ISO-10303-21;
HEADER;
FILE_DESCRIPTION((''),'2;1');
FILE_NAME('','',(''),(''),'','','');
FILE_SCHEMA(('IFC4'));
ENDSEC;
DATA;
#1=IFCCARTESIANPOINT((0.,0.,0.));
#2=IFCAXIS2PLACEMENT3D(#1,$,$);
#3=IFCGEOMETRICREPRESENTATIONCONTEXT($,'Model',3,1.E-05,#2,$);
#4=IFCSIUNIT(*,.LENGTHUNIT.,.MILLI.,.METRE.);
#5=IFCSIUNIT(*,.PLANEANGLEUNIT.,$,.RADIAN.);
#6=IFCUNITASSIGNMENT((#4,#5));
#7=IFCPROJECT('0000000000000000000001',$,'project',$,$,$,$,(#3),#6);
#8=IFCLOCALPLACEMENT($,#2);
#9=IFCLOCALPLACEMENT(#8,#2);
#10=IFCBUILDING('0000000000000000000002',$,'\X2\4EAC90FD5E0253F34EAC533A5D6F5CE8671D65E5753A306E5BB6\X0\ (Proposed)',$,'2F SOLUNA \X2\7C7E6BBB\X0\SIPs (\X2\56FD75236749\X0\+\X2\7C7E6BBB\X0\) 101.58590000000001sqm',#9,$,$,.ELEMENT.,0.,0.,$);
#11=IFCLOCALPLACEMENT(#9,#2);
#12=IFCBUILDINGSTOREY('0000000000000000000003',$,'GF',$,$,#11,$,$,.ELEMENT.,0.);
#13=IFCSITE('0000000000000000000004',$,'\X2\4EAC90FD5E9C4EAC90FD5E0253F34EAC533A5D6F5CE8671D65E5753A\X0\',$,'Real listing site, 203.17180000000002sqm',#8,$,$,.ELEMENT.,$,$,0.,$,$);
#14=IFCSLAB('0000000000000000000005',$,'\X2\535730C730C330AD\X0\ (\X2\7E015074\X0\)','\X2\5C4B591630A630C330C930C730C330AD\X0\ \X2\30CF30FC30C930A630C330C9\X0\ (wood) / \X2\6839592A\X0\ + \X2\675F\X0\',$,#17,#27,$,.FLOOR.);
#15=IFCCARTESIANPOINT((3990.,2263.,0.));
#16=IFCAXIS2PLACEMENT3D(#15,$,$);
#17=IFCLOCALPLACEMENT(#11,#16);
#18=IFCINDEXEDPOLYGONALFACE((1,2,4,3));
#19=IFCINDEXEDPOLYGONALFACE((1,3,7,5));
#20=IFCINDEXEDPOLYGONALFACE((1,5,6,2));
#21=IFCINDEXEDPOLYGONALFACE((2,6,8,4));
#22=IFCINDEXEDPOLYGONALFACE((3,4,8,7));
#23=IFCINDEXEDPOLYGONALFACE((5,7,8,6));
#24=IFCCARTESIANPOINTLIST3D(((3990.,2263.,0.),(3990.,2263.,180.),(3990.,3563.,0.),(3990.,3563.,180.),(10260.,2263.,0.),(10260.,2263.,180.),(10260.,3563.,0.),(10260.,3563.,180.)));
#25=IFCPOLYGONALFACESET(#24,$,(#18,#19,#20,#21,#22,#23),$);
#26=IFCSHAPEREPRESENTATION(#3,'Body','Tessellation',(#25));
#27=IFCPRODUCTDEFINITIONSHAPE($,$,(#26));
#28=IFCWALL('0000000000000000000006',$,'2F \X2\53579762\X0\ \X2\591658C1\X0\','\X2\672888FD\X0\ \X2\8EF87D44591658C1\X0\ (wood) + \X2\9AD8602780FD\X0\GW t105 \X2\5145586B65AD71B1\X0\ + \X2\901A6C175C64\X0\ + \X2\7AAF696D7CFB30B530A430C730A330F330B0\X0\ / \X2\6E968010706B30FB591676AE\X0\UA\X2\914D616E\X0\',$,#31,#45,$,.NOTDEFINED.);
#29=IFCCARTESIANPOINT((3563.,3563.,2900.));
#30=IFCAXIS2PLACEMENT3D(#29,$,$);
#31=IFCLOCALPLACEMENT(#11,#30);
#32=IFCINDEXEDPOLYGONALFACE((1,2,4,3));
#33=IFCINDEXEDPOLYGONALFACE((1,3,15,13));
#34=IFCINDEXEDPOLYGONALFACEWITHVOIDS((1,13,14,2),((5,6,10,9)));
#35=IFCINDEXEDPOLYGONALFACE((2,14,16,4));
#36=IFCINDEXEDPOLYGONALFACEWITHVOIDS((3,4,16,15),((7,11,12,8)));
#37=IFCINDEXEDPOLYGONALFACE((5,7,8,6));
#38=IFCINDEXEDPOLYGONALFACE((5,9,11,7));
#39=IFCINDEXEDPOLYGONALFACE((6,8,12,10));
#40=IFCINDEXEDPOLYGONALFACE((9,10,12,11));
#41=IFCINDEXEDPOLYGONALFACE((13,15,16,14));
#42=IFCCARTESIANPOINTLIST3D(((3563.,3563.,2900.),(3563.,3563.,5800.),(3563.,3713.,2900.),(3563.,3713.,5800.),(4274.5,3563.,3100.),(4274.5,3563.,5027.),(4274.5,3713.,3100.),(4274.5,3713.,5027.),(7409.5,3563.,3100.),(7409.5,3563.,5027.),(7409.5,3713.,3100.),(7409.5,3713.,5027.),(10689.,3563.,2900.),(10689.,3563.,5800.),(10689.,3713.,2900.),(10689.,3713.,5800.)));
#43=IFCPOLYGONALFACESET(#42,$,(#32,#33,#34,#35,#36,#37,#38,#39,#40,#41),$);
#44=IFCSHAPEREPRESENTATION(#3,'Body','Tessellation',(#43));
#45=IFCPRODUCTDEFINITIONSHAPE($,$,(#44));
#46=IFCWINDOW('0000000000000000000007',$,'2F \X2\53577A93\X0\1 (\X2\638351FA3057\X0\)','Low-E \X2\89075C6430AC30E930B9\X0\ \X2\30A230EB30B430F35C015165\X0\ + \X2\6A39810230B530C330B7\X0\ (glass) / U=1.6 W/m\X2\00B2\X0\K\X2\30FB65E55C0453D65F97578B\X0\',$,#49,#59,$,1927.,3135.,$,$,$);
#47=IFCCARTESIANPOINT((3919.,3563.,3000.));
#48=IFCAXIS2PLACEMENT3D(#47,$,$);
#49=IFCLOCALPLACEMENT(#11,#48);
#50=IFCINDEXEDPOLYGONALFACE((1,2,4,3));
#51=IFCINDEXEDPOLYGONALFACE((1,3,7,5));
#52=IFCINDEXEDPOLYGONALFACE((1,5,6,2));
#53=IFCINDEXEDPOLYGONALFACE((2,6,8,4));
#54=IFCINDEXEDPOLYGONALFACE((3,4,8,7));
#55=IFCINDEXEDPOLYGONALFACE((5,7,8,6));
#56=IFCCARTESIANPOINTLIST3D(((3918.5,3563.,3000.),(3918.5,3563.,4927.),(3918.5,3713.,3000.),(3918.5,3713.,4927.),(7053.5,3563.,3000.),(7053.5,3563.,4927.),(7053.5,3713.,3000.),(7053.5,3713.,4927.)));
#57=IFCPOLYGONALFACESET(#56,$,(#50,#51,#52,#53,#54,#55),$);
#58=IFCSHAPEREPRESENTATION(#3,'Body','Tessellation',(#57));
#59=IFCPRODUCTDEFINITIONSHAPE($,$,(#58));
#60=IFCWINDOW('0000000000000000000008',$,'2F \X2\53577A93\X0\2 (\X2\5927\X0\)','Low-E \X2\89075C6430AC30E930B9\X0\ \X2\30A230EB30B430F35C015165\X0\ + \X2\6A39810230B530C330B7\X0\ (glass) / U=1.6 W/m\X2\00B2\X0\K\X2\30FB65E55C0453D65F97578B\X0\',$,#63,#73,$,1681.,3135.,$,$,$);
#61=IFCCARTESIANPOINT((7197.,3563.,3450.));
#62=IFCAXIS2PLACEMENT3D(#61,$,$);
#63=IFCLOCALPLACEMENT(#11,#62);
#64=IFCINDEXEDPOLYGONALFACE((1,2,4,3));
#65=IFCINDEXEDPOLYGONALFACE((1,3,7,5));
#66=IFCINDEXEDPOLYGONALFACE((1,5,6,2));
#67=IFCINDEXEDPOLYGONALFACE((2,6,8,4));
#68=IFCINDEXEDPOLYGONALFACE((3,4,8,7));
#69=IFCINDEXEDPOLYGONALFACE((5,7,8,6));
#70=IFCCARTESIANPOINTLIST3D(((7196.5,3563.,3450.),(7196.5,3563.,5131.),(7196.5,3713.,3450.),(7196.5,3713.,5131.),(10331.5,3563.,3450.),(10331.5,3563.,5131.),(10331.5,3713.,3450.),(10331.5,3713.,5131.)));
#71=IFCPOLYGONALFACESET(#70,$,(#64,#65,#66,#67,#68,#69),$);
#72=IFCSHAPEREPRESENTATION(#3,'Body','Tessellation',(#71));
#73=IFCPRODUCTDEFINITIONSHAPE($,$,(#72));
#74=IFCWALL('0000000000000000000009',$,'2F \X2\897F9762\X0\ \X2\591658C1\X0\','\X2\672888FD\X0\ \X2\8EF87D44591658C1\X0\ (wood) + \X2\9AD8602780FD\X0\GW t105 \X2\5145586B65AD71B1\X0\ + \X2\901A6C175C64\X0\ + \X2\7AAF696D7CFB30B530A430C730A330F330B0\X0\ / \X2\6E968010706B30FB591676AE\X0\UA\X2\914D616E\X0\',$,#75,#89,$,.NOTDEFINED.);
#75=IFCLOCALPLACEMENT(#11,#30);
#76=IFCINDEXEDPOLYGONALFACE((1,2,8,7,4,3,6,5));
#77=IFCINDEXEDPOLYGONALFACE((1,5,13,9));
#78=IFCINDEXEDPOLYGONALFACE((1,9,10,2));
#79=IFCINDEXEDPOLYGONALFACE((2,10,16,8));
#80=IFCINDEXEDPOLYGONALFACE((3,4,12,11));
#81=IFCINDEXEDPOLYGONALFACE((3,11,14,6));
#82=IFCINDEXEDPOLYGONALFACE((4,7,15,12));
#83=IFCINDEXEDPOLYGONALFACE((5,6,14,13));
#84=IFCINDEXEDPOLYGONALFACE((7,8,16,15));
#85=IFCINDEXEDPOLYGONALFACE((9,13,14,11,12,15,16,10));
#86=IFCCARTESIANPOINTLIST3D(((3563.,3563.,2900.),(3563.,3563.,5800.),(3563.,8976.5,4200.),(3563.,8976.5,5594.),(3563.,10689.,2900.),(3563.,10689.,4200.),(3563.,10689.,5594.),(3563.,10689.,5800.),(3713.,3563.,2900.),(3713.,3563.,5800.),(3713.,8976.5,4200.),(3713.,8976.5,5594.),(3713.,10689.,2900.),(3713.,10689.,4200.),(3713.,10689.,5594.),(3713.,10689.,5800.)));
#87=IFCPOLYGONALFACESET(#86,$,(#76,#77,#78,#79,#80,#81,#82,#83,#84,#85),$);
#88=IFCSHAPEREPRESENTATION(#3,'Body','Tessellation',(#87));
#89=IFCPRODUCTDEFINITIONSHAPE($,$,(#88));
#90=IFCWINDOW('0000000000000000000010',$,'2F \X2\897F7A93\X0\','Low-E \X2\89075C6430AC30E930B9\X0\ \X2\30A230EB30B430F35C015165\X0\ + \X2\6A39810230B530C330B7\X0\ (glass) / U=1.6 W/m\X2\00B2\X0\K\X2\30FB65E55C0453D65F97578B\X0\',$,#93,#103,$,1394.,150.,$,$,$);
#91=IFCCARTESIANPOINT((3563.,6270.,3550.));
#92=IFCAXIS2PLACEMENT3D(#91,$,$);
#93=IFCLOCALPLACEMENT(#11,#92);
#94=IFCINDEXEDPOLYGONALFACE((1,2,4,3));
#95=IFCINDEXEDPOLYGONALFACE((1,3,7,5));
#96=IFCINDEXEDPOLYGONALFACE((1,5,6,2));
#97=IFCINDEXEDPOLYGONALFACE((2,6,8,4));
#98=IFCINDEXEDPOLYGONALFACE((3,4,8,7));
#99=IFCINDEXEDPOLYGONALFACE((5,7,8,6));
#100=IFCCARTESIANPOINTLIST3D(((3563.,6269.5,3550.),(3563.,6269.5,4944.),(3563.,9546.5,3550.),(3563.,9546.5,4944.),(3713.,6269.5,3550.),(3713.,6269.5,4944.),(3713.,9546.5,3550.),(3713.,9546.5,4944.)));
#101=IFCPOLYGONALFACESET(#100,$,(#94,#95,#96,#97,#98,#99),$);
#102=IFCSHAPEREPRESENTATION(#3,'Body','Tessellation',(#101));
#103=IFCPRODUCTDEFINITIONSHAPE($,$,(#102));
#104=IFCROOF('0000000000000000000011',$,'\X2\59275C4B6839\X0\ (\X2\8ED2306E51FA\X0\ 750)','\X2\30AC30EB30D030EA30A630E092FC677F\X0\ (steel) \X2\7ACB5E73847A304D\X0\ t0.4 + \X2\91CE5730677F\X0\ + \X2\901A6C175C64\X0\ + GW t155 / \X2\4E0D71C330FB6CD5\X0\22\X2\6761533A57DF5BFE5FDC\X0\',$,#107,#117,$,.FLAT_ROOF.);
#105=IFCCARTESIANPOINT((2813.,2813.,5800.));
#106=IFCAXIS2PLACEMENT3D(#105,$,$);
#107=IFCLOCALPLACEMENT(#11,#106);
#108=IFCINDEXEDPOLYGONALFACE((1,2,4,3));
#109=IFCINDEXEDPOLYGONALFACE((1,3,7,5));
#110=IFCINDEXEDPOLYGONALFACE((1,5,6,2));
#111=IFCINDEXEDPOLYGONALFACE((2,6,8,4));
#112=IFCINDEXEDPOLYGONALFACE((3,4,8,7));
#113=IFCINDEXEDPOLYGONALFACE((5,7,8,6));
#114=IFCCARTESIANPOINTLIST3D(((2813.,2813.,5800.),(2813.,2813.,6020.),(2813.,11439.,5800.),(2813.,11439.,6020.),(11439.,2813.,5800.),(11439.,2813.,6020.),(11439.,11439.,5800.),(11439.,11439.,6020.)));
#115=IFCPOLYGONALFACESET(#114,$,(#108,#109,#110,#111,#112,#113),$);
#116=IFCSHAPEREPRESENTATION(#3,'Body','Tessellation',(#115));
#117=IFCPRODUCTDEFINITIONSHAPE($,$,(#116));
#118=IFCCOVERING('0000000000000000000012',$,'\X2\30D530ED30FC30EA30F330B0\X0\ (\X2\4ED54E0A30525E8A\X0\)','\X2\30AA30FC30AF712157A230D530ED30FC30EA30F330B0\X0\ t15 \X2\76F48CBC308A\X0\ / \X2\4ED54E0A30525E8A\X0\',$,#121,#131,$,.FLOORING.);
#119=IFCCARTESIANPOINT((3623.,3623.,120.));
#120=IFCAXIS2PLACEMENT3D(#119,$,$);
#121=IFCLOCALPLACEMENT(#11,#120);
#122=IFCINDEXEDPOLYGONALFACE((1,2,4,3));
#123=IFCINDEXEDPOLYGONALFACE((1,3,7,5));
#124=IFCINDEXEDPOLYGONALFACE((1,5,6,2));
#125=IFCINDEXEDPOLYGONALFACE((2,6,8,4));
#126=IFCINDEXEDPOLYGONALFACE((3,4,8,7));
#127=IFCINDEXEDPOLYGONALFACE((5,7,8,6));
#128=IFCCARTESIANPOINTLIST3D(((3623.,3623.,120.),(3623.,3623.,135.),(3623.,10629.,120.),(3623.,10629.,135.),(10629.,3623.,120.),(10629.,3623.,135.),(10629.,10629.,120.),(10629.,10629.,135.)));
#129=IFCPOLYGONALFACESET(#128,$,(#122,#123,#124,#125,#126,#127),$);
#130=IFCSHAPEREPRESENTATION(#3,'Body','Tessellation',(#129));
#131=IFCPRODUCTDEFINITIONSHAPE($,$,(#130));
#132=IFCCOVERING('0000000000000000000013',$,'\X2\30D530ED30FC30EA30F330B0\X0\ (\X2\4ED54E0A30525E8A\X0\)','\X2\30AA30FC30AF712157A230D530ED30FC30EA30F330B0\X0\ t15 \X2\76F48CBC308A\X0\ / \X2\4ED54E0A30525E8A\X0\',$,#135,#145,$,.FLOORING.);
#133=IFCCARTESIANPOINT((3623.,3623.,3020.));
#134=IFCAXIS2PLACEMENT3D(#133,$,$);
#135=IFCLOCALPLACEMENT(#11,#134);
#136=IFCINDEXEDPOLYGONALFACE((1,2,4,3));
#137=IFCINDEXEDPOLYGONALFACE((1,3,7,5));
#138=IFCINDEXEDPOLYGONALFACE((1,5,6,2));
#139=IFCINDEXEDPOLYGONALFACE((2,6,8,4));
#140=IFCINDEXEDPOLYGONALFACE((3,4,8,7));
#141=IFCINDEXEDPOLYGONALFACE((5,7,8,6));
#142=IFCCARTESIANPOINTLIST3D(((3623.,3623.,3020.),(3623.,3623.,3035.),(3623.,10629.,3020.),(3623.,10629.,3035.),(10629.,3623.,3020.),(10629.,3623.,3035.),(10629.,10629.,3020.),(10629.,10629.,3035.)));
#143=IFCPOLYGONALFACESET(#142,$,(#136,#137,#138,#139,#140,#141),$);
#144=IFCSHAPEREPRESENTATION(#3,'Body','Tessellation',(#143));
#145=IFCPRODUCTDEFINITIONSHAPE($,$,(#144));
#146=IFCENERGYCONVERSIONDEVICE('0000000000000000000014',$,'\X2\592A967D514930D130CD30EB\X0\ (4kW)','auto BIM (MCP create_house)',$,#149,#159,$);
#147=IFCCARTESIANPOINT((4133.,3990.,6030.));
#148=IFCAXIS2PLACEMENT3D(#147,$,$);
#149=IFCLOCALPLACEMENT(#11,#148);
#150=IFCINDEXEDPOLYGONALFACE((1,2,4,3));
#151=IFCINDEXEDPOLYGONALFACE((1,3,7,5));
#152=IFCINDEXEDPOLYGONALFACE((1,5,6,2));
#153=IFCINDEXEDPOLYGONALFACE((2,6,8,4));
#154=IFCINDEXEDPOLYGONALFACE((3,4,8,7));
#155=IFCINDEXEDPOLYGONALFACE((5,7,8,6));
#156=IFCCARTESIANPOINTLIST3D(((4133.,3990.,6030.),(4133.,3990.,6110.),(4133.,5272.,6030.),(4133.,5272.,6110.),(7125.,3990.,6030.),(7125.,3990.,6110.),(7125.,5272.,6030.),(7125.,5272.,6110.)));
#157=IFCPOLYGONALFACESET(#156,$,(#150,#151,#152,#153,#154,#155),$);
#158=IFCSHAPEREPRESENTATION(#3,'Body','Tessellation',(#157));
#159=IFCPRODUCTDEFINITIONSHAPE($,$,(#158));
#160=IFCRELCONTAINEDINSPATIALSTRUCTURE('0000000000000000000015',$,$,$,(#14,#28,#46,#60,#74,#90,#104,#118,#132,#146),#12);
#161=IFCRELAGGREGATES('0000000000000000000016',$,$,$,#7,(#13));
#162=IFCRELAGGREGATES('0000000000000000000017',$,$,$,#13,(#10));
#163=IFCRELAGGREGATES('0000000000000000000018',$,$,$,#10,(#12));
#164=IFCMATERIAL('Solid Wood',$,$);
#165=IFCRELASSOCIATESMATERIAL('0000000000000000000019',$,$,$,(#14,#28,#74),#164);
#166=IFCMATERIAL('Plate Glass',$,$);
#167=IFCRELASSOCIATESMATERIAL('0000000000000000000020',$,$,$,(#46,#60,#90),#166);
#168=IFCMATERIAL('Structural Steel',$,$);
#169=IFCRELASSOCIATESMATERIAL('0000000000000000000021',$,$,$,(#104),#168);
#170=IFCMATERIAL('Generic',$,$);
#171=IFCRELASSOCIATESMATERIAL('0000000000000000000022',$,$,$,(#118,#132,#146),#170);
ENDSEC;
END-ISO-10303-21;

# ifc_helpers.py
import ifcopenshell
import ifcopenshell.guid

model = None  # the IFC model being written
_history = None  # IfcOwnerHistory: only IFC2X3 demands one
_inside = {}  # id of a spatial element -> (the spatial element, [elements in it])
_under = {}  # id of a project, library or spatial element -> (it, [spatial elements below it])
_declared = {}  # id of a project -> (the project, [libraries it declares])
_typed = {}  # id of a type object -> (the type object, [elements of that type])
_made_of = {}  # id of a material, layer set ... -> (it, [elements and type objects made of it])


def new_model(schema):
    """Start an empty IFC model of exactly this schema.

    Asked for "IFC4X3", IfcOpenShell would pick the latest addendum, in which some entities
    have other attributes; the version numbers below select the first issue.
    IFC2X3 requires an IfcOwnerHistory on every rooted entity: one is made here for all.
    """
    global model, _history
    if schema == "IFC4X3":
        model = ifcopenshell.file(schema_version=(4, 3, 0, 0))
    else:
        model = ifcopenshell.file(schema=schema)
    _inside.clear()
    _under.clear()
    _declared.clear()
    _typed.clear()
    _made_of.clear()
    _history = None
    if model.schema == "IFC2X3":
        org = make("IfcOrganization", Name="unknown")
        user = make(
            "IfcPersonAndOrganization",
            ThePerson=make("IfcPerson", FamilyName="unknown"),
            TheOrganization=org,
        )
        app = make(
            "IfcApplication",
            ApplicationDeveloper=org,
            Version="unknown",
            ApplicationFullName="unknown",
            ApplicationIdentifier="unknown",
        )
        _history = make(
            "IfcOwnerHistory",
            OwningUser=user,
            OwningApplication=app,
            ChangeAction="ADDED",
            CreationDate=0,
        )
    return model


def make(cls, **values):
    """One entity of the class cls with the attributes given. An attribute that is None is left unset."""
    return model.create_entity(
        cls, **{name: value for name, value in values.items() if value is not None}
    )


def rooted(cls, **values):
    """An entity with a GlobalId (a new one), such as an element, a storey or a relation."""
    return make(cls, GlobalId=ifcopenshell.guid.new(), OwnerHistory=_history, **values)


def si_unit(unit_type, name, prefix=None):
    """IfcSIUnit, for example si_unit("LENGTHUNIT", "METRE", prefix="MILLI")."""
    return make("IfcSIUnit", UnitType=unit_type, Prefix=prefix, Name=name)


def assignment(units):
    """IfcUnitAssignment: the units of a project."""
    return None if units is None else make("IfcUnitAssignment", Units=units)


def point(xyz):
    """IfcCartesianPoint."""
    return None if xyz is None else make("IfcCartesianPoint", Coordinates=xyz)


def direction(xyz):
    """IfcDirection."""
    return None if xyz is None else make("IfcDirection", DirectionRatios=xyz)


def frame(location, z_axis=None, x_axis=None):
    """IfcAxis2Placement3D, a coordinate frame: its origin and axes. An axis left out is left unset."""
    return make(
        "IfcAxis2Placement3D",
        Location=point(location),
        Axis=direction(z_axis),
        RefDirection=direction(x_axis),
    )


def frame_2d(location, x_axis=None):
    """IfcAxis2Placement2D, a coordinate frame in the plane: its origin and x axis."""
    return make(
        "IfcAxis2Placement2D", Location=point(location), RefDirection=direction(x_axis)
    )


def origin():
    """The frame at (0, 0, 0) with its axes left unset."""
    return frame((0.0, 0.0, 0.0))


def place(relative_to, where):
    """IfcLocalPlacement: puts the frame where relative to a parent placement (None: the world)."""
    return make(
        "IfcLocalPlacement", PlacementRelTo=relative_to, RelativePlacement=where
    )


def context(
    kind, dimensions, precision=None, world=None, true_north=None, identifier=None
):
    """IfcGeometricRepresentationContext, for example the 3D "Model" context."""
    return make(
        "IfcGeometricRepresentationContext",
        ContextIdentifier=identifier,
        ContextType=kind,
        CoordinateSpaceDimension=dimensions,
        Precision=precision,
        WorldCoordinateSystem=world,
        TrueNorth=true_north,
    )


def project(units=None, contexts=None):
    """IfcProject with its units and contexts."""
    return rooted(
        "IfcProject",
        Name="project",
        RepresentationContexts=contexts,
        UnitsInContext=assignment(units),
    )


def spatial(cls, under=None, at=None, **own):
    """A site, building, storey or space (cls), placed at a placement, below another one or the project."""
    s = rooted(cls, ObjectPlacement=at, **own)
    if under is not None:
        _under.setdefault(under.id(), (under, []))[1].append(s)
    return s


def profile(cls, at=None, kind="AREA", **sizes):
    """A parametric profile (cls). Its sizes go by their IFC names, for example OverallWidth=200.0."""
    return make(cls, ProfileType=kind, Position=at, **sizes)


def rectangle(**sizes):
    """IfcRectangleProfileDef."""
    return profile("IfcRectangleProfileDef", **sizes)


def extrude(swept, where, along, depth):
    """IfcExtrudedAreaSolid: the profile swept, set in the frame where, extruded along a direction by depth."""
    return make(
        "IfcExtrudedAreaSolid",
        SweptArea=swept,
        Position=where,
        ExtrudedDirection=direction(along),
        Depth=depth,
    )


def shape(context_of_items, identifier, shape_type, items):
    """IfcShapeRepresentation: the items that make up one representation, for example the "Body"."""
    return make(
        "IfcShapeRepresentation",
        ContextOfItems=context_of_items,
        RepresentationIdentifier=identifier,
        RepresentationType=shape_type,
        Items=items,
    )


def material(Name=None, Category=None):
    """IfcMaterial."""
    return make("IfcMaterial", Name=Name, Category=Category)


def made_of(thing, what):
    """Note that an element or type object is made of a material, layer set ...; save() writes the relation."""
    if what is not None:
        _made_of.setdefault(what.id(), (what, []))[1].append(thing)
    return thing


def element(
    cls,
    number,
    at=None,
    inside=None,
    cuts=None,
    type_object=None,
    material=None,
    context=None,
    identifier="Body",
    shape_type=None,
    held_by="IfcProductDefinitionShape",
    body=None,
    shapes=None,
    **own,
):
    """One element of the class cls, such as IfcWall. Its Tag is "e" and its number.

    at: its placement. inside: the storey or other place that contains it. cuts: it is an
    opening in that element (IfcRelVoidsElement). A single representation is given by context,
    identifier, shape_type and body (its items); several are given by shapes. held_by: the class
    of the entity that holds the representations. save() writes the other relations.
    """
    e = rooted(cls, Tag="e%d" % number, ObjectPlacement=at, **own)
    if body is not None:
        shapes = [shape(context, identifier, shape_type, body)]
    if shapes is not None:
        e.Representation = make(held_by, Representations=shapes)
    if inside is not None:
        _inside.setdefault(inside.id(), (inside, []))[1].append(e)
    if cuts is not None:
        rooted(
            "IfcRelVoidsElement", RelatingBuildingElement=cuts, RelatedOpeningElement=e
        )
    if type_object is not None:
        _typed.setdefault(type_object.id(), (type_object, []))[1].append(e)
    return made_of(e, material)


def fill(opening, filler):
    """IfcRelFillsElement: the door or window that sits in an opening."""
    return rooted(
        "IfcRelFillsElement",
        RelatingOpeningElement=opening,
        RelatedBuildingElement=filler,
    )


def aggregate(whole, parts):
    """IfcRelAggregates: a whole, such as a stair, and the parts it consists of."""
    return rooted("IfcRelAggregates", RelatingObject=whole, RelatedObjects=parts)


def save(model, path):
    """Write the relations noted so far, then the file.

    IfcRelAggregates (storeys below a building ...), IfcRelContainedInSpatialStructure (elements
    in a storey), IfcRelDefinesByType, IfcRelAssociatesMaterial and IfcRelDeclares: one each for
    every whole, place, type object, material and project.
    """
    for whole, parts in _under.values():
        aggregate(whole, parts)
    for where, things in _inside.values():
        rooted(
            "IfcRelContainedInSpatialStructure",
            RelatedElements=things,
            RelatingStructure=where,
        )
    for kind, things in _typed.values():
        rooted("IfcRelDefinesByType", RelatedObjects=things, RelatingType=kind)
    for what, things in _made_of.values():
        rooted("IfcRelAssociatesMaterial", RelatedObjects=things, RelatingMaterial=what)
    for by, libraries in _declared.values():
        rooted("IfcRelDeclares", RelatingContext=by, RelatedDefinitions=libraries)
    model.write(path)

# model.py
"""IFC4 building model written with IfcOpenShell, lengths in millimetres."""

from ifc_helpers import new_model, si_unit, frame, frame_2d, origin, place, context, project, spatial, rectangle, extrude, material, element, fill, save


model = new_model("IFC4")

# Units and contexts
model_context = context("Model", 3, precision=1e-05, world=origin())
ifc_project = project(units=[si_unit("LENGTHUNIT", "METRE", prefix="MILLI"), si_unit("PLANEANGLEUNIT", "RADIAN")], contexts=[model_context])

# Site, building, storey
site_placement = place(None, origin())
site = spatial("IfcSite", under=ifc_project, at=site_placement, Name="京都府京都市右京区嵯峨朝日町", ObjectType="Real listing site, 203.17180000000002sqm", CompositionType="ELEMENT", RefElevation=0.0)
building_placement = place(site_placement, origin())
building = spatial("IfcBuilding", under=site, at=building_placement, Name="京都市右京区嵯峨朝日町の家 (Proposed)", ObjectType="2F SOLUNA 籾殻SIPs (国産杉+籾殻) 101.58590000000001sqm", CompositionType="ELEMENT", ElevationOfRefHeight=0.0, ElevationOfTerrain=0.0)
storey_placement = place(building_placement, origin())
storey = spatial("IfcBuildingStorey", under=building, at=storey_placement, Name="GF", CompositionType="ELEMENT", Elevation=0.0)

# Slab
ifc_material_1 = material(Name="Solid Wood")
slab_1_placement = place(storey_placement, frame((3990.0, 2263.0, 0.0)))
element("IfcSlab", 1, at=slab_1_placement, inside=storey, material=ifc_material_1, Name="南デッキ (縁側)", Description="屋外ウッドデッキ ハードウッド (wood) / 根太 + 束", PredefinedType="FLOOR", context=model_context, shape_type="SweptSolid", body=[
    extrude(rectangle(XDim=6270.0, YDim=1300.0, at=frame_2d((3135.0, 650.0))), frame((3990.0, 2263.0, 0.0)), (0.0, 0.0, 1.0), 180.0),
])

# Shared definitions
ifc_material_2 = material(Name="Plate Glass")

# Wall, openings, windows
wall_1_placement = place(storey_placement, frame((3563.0, 3563.0, 2900.0)))
wall_1 = element("IfcWall", 2, at=wall_1_placement, inside=storey, material=ifc_material_1, Name="2F 南面 外壁", Description="木製 軸組外壁 (wood) + 高性能GW t105 充填断熱 + 通気層 + 窯業系サイディング / 準耐火・外皮UA配慮", PredefinedType="NOTDEFINED", context=model_context, shape_type="SweptSolid", body=[
    extrude(rectangle(XDim=7126.0, YDim=150.0, at=frame_2d((3563.0, 75.0))), frame((3563.0, 3563.0, 2900.0)), (0.0, 0.0, 1.0), 2900.0),
])
opening_1_placement = place(storey_placement, frame((3919.0, 3563.0, 3000.0)))
opening_1 = element("IfcOpeningElement", 3, at=opening_1_placement, cuts=wall_1, PredefinedType="NOTDEFINED", context=model_context, shape_type="SweptSolid", body=[
    extrude(rectangle(XDim=3135.0, YDim=150.0, at=frame_2d((1567.0, 75.0))), frame((3919.0, 3563.0, 3000.0)), (0.0, 0.0, 1.0), 1927.0),
])
opening_2_placement = place(storey_placement, frame((7197.0, 3563.0, 3450.0)))
opening_2 = element("IfcOpeningElement", 4, at=opening_2_placement, cuts=wall_1, PredefinedType="NOTDEFINED", context=model_context, shape_type="SweptSolid", body=[
    extrude(rectangle(XDim=3135.0, YDim=150.0, at=frame_2d((1567.0, 75.0))), frame((7197.0, 3563.0, 3450.0)), (0.0, 0.0, 1.0), 1681.0),
])
window_1_placement = place(storey_placement, frame((3919.0, 3563.0, 3000.0)))
window_1 = element("IfcWindow", 5, at=window_1_placement, inside=storey, material=ifc_material_2, Name="2F 南窓1 (掃出し)", Description="Low-E 複層ガラス アルゴン封入 + 樹脂サッシ (glass) / U=1.6 W/m²K・日射取得型", OverallHeight=1927.0, OverallWidth=3135.0, context=model_context, shape_type="SweptSolid", body=[
    extrude(rectangle(XDim=3135.0, YDim=150.0, at=frame_2d((1567.0, 75.0))), frame((3919.0, 3563.0, 3000.0)), (0.0, 0.0, 1.0), 1927.0),
])
fill(opening_1, window_1)
window_2_placement = place(storey_placement, frame((7197.0, 3563.0, 3450.0)))
window_2 = element("IfcWindow", 6, at=window_2_placement, inside=storey, material=ifc_material_2, Name="2F 南窓2 (大)", Description="Low-E 複層ガラス アルゴン封入 + 樹脂サッシ (glass) / U=1.6 W/m²K・日射取得型", OverallHeight=1681.0, OverallWidth=3135.0, context=model_context, shape_type="SweptSolid", body=[
    extrude(rectangle(XDim=3135.0, YDim=150.0, at=frame_2d((1567.0, 75.0))), frame((7197.0, 3563.0, 3450.0)), (0.0, 0.0, 1.0), 1681.0),
])
fill(opening_2, window_2)

# Wall, opening, window
wall_2_placement = place(storey_placement, frame((3563.0, 3563.0, 2900.0)))
wall_2 = element("IfcWall", 7, at=wall_2_placement, inside=storey, material=ifc_material_1, Name="2F 西面 外壁", Description="木製 軸組外壁 (wood) + 高性能GW t105 充填断熱 + 通気層 + 窯業系サイディング / 準耐火・外皮UA配慮", PredefinedType="NOTDEFINED", context=model_context, shape_type="SweptSolid", body=[
    extrude(rectangle(XDim=150.0, YDim=7126.0, at=frame_2d((75.0, 3563.0))), frame((3563.0, 3563.0, 2900.0)), (0.0, 0.0, 1.0), 2900.0),
])
opening_3_placement = place(storey_placement, frame((3563.0, 6270.0, 3550.0)))
opening_3 = element("IfcOpeningElement", 8, at=opening_3_placement, cuts=wall_2, PredefinedType="NOTDEFINED", context=model_context, shape_type="SweptSolid", body=[
    extrude(rectangle(XDim=150.0, YDim=3277.0, at=frame_2d((75.0, 1638.0))), frame((3563.0, 6270.0, 3550.0)), (0.0, 0.0, 1.0), 1394.0),
])
window_3_placement = place(storey_placement, frame((3563.0, 6270.0, 3550.0)))
window_3 = element("IfcWindow", 9, at=window_3_placement, inside=storey, material=ifc_material_2, Name="2F 西窓", Description="Low-E 複層ガラス アルゴン封入 + 樹脂サッシ (glass) / U=1.6 W/m²K・日射取得型", OverallHeight=1394.0, OverallWidth=150.0, context=model_context, shape_type="SweptSolid", body=[
    extrude(rectangle(XDim=150.0, YDim=3277.0, at=frame_2d((75.0, 1638.0))), frame((3563.0, 6270.0, 3550.0)), (0.0, 0.0, 1.0), 1394.0),
])
fill(opening_3, window_3)

# Roof
ifc_material_3 = material(Name="Structural Steel")
roof_placement = place(storey_placement, frame((2813.0, 2813.0, 5800.0)))
element("IfcRoof", 10, at=roof_placement, inside=storey, material=ifc_material_3, Name="大屋根 (軒の出 750)", Description="ガルバリウム鋼板 (steel) 立平葺き t0.4 + 野地板 + 通気層 + GW t155 / 不燃・法22条区域対応", PredefinedType="FLAT_ROOF", context=model_context, shape_type="SweptSolid", body=[
    extrude(rectangle(XDim=8626.0, YDim=8626.0, at=frame_2d((4313.0, 4313.0))), frame((2813.0, 2813.0, 5800.0)), (0.0, 0.0, 1.0), 220.0),
])

# Coverings
ifc_material_4 = material(Name="Generic")
covering_1_placement = place(storey_placement, frame((3623.0, 3623.0, 120.0)))
element("IfcCovering", 11, at=covering_1_placement, inside=storey, material=ifc_material_4, Name="フローリング (仕上げ床)", Description="オーク無垢フローリング t15 直貼り / 仕上げ床", PredefinedType="FLOORING", context=model_context, shape_type="SweptSolid", body=[
    extrude(rectangle(XDim=7006.0, YDim=7006.0, at=frame_2d((3503.0, 3503.0))), frame((3623.0, 3623.0, 120.0)), (0.0, 0.0, 1.0), 15.0),
])
covering_2_placement = place(storey_placement, frame((3623.0, 3623.0, 3020.0)))
element("IfcCovering", 12, at=covering_2_placement, inside=storey, material=ifc_material_4, Name="フローリング (仕上げ床)", Description="オーク無垢フローリング t15 直貼り / 仕上げ床", PredefinedType="FLOORING", context=model_context, shape_type="SweptSolid", body=[
    extrude(rectangle(XDim=7006.0, YDim=7006.0, at=frame_2d((3503.0, 3503.0))), frame((3623.0, 3623.0, 3020.0)), (0.0, 0.0, 1.0), 15.0),
])

# Energy conversion device
energy_conversion_device_placement = place(storey_placement, frame((4133.0, 3990.0, 6030.0)))
element("IfcEnergyConversionDevice", 13, at=energy_conversion_device_placement, inside=storey, material=ifc_material_4, Name="太陽光パネル (4kW)", Description="auto BIM (MCP create_house)", context=model_context, shape_type="SweptSolid", body=[
    extrude(rectangle(XDim=2992.0, YDim=1282.0, at=frame_2d((1496.0, 641.0))), frame((4133.0, 3990.0, 6030.0)), (0.0, 0.0, 1.0), 80.0),
])

save(model, "model.ifc")
